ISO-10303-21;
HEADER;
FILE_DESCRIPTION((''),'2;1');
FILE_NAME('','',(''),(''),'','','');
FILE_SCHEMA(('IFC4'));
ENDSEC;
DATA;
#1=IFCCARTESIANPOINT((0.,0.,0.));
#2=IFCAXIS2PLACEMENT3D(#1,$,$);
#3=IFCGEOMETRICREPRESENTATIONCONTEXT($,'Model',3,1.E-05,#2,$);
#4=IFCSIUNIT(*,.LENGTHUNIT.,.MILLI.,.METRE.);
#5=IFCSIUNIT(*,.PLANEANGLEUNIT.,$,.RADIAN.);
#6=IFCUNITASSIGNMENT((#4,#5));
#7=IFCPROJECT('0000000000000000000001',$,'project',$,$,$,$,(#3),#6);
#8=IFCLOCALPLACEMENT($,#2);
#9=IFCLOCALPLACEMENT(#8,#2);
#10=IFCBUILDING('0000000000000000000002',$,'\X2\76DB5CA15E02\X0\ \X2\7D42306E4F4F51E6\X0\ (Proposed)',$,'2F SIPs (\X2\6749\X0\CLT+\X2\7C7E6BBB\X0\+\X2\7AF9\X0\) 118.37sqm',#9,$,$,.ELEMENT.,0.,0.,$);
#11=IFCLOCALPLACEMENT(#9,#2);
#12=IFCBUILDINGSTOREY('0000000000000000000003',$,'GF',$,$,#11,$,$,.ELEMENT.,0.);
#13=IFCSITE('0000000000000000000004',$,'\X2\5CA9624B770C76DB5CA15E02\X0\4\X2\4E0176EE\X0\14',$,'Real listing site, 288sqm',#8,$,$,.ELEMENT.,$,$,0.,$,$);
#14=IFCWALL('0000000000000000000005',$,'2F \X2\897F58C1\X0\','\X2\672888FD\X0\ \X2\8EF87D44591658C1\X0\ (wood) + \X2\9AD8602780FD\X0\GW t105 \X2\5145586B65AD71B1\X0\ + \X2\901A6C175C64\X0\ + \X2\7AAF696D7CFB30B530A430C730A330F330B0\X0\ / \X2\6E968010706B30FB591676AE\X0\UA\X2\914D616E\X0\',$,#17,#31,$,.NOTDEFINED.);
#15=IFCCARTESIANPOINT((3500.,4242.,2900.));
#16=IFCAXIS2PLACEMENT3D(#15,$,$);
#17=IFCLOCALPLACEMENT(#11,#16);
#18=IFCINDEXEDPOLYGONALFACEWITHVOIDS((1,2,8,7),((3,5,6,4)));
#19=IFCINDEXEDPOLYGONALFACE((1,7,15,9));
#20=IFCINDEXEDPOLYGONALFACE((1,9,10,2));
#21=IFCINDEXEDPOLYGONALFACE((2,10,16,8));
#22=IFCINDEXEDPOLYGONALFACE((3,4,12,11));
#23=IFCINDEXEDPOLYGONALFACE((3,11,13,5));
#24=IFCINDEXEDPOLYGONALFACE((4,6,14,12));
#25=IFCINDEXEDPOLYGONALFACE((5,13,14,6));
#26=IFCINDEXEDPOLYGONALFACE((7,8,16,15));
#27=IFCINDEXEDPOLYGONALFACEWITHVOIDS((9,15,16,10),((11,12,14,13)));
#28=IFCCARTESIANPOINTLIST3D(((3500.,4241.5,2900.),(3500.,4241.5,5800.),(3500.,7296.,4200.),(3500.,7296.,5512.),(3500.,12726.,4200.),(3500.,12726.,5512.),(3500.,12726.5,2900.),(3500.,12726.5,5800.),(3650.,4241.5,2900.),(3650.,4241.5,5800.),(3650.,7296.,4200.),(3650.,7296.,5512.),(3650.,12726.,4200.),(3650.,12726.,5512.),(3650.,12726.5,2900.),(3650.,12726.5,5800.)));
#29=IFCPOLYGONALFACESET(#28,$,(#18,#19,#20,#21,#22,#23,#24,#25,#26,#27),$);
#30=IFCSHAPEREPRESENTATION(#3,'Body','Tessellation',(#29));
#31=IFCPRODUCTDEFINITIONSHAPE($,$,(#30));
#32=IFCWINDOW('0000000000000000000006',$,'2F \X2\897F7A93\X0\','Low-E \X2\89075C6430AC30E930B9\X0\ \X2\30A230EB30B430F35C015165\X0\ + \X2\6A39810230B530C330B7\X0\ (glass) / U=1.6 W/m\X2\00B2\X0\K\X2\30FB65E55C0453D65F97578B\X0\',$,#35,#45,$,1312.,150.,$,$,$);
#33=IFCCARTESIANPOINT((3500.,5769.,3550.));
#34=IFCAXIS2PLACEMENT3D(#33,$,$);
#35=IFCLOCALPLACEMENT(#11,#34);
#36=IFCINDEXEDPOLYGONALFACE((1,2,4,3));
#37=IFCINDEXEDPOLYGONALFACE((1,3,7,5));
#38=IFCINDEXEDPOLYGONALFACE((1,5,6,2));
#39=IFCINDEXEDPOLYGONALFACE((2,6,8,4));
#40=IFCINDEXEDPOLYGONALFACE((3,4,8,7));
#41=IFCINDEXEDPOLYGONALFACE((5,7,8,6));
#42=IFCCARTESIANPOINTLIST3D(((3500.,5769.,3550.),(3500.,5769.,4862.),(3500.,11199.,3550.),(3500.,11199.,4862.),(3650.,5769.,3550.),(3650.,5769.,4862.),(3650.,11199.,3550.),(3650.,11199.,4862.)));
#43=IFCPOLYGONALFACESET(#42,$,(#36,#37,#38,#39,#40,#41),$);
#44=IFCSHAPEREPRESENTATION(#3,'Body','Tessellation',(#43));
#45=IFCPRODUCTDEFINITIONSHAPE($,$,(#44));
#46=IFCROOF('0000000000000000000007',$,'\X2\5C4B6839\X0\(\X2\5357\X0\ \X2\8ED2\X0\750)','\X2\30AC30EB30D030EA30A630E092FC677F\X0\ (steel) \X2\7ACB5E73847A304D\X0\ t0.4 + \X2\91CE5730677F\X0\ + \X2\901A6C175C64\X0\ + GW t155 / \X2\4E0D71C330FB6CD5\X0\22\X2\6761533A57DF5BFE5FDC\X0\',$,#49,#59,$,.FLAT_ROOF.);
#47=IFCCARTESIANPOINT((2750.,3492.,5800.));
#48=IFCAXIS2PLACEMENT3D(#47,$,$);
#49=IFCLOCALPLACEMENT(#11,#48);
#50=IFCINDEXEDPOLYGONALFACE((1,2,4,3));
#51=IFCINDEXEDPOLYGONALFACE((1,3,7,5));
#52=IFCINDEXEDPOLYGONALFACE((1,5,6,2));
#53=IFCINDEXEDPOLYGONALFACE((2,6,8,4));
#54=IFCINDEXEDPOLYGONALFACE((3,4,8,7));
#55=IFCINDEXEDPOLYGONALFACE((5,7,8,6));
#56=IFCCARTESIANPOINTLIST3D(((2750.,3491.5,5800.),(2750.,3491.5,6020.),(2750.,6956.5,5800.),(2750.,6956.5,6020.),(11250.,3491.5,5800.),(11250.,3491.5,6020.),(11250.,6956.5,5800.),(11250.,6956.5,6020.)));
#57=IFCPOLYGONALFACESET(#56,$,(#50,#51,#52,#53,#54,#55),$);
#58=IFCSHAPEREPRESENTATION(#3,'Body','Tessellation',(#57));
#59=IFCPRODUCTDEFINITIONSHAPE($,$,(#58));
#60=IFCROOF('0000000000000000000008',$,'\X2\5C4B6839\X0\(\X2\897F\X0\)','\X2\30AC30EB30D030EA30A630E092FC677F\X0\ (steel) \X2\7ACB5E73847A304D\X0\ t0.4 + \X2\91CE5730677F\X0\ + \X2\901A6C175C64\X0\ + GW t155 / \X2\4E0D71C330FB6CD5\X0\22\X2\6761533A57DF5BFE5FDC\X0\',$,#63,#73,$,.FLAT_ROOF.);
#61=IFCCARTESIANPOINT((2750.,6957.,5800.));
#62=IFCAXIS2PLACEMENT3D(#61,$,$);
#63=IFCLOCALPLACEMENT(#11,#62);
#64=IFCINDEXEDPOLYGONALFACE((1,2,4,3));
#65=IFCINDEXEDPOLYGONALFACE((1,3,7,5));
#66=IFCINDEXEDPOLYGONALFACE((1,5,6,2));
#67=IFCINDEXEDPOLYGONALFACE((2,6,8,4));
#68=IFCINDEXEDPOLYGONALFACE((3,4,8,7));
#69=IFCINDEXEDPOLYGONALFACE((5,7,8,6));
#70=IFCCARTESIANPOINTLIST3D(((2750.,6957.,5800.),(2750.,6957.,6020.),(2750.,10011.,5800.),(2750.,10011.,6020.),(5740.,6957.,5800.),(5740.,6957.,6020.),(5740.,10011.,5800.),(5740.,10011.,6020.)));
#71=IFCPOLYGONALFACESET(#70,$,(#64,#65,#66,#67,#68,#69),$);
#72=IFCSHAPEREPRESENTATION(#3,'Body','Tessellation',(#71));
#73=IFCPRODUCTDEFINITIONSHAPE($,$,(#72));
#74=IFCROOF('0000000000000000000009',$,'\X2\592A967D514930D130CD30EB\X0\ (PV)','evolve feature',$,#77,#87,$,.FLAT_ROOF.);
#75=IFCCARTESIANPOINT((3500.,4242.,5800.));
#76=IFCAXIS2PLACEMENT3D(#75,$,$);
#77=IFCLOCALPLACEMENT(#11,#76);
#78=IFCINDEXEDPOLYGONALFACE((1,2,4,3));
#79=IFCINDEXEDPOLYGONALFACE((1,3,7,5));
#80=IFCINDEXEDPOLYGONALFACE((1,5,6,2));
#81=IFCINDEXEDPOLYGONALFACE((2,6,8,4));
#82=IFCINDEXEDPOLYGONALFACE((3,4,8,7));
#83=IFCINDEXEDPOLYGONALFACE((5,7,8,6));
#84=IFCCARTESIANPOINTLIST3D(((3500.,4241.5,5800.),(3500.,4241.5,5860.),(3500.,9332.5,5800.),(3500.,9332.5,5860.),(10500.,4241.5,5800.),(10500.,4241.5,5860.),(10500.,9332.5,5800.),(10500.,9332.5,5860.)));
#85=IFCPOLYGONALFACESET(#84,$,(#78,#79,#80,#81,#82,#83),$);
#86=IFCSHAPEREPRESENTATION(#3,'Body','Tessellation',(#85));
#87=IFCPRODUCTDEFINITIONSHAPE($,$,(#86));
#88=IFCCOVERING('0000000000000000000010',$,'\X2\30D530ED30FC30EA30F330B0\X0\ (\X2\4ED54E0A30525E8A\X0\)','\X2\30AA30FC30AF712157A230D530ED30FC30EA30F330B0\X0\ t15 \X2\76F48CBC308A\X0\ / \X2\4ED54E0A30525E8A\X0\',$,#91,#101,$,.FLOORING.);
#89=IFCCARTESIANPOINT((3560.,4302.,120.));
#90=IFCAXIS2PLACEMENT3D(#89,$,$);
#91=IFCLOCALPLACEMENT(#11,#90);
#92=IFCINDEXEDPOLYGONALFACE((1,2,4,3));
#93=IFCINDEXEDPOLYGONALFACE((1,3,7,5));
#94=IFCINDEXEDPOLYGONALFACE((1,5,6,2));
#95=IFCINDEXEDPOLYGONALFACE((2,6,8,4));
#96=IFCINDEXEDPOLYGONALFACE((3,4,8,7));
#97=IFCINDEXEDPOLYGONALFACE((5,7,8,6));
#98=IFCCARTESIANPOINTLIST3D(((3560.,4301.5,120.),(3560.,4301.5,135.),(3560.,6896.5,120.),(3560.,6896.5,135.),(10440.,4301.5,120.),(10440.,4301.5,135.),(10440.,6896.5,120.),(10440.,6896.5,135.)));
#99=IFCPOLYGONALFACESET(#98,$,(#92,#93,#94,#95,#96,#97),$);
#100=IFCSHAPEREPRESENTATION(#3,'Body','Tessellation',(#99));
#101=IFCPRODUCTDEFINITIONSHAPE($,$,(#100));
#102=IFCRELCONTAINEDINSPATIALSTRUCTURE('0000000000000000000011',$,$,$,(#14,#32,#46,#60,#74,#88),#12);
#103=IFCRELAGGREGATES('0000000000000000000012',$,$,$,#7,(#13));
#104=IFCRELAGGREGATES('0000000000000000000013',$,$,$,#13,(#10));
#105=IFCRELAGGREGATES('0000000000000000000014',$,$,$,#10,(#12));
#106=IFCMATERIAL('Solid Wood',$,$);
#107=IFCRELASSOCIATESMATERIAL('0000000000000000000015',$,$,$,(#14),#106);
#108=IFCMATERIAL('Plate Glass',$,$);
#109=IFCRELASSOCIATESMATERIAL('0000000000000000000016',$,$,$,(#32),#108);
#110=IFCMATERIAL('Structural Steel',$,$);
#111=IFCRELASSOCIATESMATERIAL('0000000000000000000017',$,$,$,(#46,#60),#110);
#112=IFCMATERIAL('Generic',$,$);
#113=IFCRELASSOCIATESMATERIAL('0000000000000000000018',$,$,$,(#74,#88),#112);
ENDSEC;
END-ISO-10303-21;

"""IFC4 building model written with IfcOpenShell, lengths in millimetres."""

from ifc_helpers import new_model, si_unit, frame, frame_2d, origin, place, context, project, spatial, rectangle, extrude, material, element, fill, save


model = new_model("IFC4")

# Units and contexts
model_context = context("Model", 3, precision=1e-05, world=origin())
ifc_project = project(units=[si_unit("LENGTHUNIT", "METRE", prefix="MILLI"), si_unit("PLANEANGLEUNIT", "RADIAN")], contexts=[model_context])

# Site, building, storey
site_placement = place(None, origin())
site = spatial("IfcSite", under=ifc_project, at=site_placement, Name="岩手県盛岡市4丁目14", ObjectType="Real listing site, 288sqm", CompositionType="ELEMENT", RefElevation=0.0)
building_placement = place(site_placement, origin())
building = spatial("IfcBuilding", under=site, at=building_placement, Name="盛岡市 終の住処 (Proposed)", ObjectType="2F SIPs (杉CLT+籾殻+竹) 118.37sqm", CompositionType="ELEMENT", ElevationOfRefHeight=0.0, ElevationOfTerrain=0.0)
storey_placement = place(building_placement, origin())
storey = spatial("IfcBuildingStorey", under=building, at=storey_placement, Name="GF", CompositionType="ELEMENT", Elevation=0.0)

# Shared definitions
ifc_material_1 = material(Name="Solid Wood")
ifc_material_2 = material(Name="Generic")

# Shared definitions
ifc_material_3 = material(Name="Plate Glass")

# Wall, opening, window
wall_1_placement = place(storey_placement, frame((3500.0, 4242.0, 2900.0)))
wall_1 = element("IfcWall", 1, at=wall_1_placement, inside=storey, material=ifc_material_1, Name="2F 西壁", Description="木製 軸組外壁 (wood) + 高性能GW t105 充填断熱 + 通気層 + 窯業系サイディング / 準耐火・外皮UA配慮", PredefinedType="NOTDEFINED", context=model_context, shape_type="SweptSolid", body=[
    extrude(rectangle(XDim=150.0, YDim=8485.0, at=frame_2d((75.0, 4242.0))), frame((3500.0, 4242.0, 2900.0)), (0.0, 0.0, 1.0), 2900.0),
])
opening_1_placement = place(storey_placement, frame((3500.0, 5769.0, 3550.0)))
opening_1 = element("IfcOpeningElement", 2, at=opening_1_placement, cuts=wall_1, PredefinedType="NOTDEFINED", context=model_context, shape_type="SweptSolid", body=[
    extrude(rectangle(XDim=150.0, YDim=5430.0, at=frame_2d((75.0, 2715.0))), frame((3500.0, 5769.0, 3550.0)), (0.0, 0.0, 1.0), 1312.0),
])
window_1_placement = place(storey_placement, frame((3500.0, 5769.0, 3550.0)))
window_1 = element("IfcWindow", 3, at=window_1_placement, inside=storey, material=ifc_material_3, Name="2F 西窓", Description="Low-E 複層ガラス アルゴン封入 + 樹脂サッシ (glass) / U=1.6 W/m²K・日射取得型", OverallHeight=1312.0, OverallWidth=150.0, context=model_context, shape_type="SweptSolid", body=[
    extrude(rectangle(XDim=150.0, YDim=5430.0, at=frame_2d((75.0, 2715.0))), frame((3500.0, 5769.0, 3550.0)), (0.0, 0.0, 1.0), 1312.0),
])
fill(opening_1, window_1)

# Roofs
ifc_material_4 = material(Name="Structural Steel")
roof_1_placement = place(storey_placement, frame((2750.0, 3492.0, 5800.0)))
element("IfcRoof", 4, at=roof_1_placement, inside=storey, material=ifc_material_4, Name="屋根(南 軒750)", Description="ガルバリウム鋼板 (steel) 立平葺き t0.4 + 野地板 + 通気層 + GW t155 / 不燃・法22条区域対応", PredefinedType="FLAT_ROOF", context=model_context, shape_type="SweptSolid", body=[
    extrude(rectangle(XDim=8500.0, YDim=3465.0, at=frame_2d((4250.0, 1732.0))), frame((2750.0, 3492.0, 5800.0)), (0.0, 0.0, 1.0), 220.0),
])
roof_2_placement = place(storey_placement, frame((2750.0, 6957.0, 5800.0)))
element("IfcRoof", 5, at=roof_2_placement, inside=storey, material=ifc_material_4, Name="屋根(西)", Description="ガルバリウム鋼板 (steel) 立平葺き t0.4 + 野地板 + 通気層 + GW t155 / 不燃・法22条区域対応", PredefinedType="FLAT_ROOF", context=model_context, shape_type="SweptSolid", body=[
    extrude(rectangle(XDim=2990.0, YDim=3054.0, at=frame_2d((1495.0, 1527.0))), frame((2750.0, 6957.0, 5800.0)), (0.0, 0.0, 1.0), 220.0),
])
roof_3_placement = place(storey_placement, frame((3500.0, 4242.0, 5800.0)))
element("IfcRoof", 6, at=roof_3_placement, inside=storey, material=ifc_material_2, Name="太陽光パネル (PV)", Description="evolve feature", PredefinedType="FLAT_ROOF", context=model_context, shape_type="SweptSolid", body=[
    extrude(rectangle(XDim=7000.0, YDim=5091.0, at=frame_2d((3500.0, 2545.0))), frame((3500.0, 4242.0, 5800.0)), (0.0, 0.0, 1.0), 60.0),
])

# Covering
covering_placement = place(storey_placement, frame((3560.0, 4302.0, 120.0)))
element("IfcCovering", 7, at=covering_placement, inside=storey, material=ifc_material_2, Name="フローリング (仕上げ床)", Description="オーク無垢フローリング t15 直貼り / 仕上げ床", PredefinedType="FLOORING", context=model_context, shape_type="SweptSolid", body=[
    extrude(rectangle(XDim=6880.0, YDim=2595.0, at=frame_2d((3440.0, 1297.0))), frame((3560.0, 4302.0, 120.0)), (0.0, 0.0, 1.0), 15.0),
])

save(model, "model.ifc")
